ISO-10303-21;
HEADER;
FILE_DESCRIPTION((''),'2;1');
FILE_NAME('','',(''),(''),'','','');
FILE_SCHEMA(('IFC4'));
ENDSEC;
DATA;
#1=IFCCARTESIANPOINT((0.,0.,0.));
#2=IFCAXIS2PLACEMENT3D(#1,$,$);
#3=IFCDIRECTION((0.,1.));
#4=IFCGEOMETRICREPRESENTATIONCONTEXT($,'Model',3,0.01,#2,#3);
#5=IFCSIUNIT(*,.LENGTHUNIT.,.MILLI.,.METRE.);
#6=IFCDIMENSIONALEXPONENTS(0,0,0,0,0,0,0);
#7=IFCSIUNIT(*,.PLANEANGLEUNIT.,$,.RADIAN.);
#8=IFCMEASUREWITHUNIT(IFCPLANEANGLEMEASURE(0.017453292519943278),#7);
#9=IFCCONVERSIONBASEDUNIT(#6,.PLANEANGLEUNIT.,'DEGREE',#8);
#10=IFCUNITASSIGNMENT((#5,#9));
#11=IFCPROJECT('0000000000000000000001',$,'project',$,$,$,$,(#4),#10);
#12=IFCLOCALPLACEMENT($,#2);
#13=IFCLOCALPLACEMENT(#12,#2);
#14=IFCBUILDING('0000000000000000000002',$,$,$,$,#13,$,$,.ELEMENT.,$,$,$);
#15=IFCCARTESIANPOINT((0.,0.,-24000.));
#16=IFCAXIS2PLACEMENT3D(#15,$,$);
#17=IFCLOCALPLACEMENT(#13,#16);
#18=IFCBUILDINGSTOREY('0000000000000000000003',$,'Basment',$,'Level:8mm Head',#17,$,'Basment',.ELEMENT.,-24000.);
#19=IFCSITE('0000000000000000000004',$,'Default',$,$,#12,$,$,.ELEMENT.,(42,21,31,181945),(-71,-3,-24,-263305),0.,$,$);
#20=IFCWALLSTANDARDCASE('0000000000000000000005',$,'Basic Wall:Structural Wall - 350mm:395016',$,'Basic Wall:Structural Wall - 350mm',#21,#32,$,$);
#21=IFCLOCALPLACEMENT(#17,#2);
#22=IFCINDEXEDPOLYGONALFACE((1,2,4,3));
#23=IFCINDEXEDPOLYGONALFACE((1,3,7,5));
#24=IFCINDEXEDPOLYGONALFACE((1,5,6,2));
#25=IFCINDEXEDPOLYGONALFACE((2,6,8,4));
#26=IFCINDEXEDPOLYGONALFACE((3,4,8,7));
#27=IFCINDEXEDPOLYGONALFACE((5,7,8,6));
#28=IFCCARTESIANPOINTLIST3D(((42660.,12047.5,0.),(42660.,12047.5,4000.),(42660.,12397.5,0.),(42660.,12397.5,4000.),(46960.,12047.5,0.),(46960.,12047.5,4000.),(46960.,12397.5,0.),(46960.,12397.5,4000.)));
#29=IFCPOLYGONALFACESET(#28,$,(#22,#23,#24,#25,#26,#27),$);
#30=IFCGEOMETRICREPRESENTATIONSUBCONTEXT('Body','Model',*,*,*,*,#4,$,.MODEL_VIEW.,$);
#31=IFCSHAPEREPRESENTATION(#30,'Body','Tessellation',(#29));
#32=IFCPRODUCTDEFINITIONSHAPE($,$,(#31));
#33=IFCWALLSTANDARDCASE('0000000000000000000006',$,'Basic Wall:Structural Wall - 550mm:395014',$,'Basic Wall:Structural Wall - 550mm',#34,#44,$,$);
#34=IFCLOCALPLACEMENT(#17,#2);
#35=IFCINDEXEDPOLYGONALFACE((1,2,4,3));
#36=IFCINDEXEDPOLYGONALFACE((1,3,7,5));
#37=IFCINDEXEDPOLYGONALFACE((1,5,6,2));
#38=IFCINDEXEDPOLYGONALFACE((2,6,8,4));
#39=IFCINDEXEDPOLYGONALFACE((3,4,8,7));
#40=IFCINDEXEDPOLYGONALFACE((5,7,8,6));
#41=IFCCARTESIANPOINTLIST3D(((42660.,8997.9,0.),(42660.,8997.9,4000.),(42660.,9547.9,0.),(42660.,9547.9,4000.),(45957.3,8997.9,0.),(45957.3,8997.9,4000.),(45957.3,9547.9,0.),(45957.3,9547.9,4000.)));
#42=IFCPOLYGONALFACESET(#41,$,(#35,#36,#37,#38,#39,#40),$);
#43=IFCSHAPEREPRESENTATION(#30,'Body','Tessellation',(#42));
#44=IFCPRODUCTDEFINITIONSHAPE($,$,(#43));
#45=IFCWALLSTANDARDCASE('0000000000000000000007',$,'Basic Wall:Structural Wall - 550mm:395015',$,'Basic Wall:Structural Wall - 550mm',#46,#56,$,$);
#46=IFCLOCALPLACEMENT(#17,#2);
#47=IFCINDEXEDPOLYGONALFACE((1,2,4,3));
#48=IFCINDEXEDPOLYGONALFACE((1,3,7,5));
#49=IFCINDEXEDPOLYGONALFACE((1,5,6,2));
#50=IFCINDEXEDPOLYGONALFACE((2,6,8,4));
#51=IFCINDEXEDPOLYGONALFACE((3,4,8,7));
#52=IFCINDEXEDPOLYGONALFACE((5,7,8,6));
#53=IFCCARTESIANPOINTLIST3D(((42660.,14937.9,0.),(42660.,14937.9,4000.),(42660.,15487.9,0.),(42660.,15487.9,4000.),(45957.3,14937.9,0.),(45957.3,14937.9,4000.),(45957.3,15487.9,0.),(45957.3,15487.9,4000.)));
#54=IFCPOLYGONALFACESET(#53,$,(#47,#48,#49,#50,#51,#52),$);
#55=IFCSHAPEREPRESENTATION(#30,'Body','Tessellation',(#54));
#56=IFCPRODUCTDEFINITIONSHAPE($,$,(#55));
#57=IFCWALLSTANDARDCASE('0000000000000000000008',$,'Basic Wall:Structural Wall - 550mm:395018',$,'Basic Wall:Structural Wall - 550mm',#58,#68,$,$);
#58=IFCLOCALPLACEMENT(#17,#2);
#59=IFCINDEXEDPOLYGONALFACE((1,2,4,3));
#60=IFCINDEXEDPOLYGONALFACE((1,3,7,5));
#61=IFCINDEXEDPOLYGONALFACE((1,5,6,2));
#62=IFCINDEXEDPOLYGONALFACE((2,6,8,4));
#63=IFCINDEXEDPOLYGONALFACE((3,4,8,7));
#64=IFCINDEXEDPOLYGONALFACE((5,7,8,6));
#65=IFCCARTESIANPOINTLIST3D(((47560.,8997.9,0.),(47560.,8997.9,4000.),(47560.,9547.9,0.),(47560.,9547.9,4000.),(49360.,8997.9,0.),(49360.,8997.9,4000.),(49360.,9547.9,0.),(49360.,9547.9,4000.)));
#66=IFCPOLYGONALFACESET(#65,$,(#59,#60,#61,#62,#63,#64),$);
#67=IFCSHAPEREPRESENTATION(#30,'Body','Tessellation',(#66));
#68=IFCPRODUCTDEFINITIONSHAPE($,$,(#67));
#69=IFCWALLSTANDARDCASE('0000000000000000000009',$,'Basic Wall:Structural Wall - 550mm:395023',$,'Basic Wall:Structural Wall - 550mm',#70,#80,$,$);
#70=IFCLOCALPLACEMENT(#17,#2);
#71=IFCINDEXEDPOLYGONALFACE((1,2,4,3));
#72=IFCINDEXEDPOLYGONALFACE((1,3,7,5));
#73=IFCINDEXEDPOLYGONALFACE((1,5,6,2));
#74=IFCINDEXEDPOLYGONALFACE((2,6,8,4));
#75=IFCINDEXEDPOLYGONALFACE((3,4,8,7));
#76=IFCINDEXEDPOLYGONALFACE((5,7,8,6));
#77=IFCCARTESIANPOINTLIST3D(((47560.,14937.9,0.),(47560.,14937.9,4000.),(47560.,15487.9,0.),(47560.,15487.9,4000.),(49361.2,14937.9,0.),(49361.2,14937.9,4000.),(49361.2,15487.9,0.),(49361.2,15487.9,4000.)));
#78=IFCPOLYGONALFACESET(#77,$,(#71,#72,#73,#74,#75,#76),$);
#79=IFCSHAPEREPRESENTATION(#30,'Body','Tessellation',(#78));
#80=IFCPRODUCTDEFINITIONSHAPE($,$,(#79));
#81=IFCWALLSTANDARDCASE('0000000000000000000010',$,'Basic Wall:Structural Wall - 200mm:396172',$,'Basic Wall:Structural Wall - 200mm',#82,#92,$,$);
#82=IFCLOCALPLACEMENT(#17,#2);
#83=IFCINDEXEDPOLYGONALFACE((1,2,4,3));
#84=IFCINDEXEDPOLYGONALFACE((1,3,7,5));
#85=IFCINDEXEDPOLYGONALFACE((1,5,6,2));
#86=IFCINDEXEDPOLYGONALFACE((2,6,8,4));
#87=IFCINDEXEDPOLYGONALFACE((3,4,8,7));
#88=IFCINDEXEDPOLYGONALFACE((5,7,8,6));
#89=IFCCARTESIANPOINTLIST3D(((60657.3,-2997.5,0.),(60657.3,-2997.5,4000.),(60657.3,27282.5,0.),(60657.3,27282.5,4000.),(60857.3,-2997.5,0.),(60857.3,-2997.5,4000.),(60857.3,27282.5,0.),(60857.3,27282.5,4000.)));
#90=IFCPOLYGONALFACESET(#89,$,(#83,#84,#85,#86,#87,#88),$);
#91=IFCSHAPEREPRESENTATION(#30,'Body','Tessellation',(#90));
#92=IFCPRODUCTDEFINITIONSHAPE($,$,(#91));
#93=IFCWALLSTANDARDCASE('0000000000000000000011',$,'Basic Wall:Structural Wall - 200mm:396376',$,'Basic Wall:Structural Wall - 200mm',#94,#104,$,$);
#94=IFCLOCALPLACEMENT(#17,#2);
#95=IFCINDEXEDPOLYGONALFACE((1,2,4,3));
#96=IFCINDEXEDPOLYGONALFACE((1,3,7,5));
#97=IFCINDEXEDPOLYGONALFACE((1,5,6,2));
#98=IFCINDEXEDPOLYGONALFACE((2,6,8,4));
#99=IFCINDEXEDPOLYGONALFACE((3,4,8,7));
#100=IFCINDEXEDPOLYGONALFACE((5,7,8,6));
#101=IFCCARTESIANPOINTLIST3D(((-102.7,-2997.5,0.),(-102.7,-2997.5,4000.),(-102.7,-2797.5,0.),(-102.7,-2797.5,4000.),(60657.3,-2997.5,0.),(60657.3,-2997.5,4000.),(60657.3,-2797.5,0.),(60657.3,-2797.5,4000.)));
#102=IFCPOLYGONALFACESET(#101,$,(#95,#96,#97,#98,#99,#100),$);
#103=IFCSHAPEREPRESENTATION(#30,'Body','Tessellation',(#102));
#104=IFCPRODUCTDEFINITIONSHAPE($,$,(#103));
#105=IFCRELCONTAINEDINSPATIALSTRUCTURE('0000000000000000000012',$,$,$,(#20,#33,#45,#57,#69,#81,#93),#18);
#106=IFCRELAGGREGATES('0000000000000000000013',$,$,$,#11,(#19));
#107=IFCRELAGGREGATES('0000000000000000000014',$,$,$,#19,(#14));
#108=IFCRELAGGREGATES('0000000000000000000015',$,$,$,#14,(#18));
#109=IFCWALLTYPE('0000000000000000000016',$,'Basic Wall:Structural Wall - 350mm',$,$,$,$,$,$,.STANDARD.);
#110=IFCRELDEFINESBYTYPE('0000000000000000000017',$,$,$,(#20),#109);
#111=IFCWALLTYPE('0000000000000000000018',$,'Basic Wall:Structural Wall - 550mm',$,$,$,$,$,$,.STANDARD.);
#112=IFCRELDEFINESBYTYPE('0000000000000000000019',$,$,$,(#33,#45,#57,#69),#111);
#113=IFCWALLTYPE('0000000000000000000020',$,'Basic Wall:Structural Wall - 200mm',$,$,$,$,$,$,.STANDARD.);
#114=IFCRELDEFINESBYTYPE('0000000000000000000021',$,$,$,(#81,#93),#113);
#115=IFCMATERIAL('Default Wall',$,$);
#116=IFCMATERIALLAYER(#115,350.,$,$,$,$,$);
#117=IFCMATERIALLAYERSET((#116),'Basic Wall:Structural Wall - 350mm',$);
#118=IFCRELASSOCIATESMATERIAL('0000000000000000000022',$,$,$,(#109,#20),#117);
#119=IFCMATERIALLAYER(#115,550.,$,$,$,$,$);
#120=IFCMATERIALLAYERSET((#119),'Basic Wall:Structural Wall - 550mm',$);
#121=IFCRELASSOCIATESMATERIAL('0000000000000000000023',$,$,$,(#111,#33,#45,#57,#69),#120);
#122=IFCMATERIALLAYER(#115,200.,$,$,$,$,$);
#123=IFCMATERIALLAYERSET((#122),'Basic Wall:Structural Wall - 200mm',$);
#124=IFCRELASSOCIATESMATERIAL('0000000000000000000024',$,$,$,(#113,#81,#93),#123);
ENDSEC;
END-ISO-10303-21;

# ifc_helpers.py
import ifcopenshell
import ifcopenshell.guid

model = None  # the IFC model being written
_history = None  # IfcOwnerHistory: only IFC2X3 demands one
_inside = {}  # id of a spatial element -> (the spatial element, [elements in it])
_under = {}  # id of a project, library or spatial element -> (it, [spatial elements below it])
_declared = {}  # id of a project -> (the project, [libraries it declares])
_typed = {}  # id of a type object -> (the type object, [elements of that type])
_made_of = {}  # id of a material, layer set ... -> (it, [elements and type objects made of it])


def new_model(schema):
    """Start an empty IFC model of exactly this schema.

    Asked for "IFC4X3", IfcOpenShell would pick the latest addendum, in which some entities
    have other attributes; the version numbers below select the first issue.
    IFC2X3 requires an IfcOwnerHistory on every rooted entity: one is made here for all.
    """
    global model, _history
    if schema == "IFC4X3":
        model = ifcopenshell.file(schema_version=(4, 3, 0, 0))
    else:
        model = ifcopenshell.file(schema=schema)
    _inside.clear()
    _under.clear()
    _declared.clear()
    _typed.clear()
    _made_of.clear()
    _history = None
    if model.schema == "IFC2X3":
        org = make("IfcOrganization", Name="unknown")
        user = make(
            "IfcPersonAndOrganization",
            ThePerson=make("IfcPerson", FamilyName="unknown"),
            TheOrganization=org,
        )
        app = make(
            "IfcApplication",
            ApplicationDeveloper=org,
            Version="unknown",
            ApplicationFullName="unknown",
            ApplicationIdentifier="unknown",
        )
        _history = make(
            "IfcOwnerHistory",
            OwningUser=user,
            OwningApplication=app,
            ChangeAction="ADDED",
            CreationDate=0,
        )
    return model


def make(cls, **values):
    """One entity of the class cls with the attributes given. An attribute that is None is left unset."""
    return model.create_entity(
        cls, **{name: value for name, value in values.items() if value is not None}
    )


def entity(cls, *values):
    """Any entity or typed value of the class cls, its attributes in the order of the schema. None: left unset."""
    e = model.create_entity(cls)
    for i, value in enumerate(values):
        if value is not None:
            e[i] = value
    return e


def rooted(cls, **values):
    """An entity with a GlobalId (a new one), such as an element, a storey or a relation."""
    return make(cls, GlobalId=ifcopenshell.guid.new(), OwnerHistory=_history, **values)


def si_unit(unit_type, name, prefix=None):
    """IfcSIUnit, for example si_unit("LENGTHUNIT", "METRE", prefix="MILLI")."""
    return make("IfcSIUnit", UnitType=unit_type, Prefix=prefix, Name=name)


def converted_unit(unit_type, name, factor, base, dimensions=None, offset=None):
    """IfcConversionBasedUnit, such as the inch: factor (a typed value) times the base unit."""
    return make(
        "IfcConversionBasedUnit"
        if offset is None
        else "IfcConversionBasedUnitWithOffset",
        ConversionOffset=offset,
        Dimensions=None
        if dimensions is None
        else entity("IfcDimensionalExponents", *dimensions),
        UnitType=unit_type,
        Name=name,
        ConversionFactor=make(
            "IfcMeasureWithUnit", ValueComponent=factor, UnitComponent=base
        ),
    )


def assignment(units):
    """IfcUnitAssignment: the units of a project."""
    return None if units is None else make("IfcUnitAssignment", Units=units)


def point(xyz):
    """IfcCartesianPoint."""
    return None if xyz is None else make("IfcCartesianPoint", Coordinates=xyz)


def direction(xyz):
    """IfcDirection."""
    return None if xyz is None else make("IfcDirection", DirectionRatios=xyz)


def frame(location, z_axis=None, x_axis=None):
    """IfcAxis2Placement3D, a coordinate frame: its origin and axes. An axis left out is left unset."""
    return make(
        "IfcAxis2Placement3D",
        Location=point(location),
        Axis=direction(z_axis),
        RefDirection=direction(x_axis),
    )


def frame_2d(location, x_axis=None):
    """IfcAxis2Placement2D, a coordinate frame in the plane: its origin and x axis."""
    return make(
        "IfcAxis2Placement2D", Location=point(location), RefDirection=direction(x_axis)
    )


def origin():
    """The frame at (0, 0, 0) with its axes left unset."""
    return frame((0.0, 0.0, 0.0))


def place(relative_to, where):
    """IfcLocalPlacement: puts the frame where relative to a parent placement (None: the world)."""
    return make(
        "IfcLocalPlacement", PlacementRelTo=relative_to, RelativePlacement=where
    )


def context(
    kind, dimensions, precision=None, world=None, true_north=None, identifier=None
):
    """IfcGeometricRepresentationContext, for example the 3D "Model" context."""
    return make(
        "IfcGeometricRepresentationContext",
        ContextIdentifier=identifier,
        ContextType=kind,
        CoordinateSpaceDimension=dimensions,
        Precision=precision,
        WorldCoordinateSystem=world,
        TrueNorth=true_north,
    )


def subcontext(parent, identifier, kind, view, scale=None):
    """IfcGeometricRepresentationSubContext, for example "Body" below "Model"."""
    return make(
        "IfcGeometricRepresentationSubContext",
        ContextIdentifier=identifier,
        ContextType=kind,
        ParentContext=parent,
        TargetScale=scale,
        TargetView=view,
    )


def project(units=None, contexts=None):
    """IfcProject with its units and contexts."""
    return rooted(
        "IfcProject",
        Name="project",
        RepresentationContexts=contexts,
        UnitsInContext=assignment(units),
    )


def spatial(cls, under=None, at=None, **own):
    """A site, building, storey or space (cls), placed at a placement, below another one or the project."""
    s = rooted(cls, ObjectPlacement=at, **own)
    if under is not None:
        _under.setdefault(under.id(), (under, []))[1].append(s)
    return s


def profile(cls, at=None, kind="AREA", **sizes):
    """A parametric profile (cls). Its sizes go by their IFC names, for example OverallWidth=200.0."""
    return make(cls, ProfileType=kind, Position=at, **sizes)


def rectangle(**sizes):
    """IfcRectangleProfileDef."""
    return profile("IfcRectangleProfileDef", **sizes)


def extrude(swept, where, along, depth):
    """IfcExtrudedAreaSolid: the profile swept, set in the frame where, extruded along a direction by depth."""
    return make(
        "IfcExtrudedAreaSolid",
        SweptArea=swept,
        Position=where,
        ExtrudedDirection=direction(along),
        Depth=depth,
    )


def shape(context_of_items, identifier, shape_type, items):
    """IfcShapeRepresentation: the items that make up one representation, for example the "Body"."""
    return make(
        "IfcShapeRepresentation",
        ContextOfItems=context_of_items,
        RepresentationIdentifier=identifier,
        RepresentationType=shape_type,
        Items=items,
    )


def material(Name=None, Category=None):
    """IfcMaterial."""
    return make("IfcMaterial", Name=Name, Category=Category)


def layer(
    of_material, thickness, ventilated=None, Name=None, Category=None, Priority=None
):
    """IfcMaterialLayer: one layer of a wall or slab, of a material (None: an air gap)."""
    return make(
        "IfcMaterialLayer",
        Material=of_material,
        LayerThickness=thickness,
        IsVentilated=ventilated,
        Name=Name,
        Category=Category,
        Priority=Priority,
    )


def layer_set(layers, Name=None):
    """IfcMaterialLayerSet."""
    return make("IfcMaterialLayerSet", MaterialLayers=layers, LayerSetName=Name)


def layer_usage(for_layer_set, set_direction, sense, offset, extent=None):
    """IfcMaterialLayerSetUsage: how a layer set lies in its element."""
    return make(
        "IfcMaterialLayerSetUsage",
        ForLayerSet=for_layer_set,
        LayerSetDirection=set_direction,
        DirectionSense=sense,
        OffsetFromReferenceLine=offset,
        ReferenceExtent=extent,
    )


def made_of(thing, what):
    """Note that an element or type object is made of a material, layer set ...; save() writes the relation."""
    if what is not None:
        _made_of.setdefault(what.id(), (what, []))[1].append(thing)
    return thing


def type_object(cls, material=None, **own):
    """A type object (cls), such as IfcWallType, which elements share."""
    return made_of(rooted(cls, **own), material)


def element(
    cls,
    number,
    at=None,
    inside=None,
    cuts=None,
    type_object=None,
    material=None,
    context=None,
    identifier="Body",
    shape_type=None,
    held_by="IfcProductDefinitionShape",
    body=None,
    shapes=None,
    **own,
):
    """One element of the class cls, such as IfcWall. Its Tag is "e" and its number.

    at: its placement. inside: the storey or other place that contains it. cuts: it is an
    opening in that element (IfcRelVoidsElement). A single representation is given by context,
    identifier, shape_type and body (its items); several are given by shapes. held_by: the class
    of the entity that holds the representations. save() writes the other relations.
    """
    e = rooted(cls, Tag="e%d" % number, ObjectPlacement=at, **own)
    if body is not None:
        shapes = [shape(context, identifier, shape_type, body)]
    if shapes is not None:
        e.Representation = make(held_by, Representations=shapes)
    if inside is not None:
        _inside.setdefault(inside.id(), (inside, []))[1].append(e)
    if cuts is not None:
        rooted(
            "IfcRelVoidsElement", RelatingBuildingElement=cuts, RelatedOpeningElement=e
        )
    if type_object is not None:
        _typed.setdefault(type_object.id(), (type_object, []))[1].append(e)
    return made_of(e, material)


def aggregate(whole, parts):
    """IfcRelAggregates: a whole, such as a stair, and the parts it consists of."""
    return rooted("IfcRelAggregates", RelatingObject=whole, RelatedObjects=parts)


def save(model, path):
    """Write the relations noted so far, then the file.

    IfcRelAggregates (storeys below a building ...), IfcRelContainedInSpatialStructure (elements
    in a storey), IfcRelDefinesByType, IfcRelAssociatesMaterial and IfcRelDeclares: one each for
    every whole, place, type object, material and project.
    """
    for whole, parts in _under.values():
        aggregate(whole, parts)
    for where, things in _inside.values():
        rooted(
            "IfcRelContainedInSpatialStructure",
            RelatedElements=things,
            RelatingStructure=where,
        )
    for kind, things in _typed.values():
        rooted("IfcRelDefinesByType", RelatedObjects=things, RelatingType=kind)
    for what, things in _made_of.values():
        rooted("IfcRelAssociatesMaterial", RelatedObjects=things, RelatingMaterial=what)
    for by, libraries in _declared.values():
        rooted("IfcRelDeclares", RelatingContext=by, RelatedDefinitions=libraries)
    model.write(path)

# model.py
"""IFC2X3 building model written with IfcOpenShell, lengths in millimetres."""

from ifc_helpers import new_model, entity, si_unit, converted_unit, direction, frame, frame_2d, origin, place, context, subcontext, project, spatial, rectangle, extrude, material, layer, layer_set, layer_usage, type_object, element, save


model = new_model("IFC2X3")

# Units and contexts
model_context = context("Model", 3, precision=0.01, world=origin(), true_north=direction((0.0, 1.0)))
body_context = subcontext(model_context, "Body", "Model", "MODEL_VIEW")
ifc_project = project(units=[si_unit("LENGTHUNIT", "METRE", prefix="MILLI"), converted_unit("PLANEANGLEUNIT", "DEGREE", entity("IfcPlaneAngleMeasure", 0.017453292519943278), si_unit("PLANEANGLEUNIT", "RADIAN"), dimensions=[0, 0, 0, 0, 0, 0, 0])], contexts=[model_context])

# Site, building, storey
site_placement = place(None, origin())
site = spatial("IfcSite", under=ifc_project, at=site_placement, Name="Default", CompositionType="ELEMENT", RefLatitude=(42, 21, 31, 181945), RefLongitude=(-71, -3, -24, -263305), RefElevation=0.0)
building_placement = place(site_placement, origin())
building = spatial("IfcBuilding", under=site, at=building_placement, CompositionType="ELEMENT")
storey_placement = place(building_placement, frame((0.0, 0.0, -24000.0)))
storey = spatial("IfcBuildingStorey", under=building, at=storey_placement, Name="Basment", ObjectType="Level:8mm Head", LongName="Basment", CompositionType="ELEMENT", Elevation=-24000.0)

# Walls
ifc_material_1 = material(Name="Default Wall")
ifc_layer_1 = layer(ifc_material_1, 350.0)
ifc_layer_set_1 = layer_set([ifc_layer_1], Name="Basic Wall:Structural Wall - 350mm")
ifc_layer_usage_1 = layer_usage(ifc_layer_set_1, "AXIS2", "NEGATIVE", 175.0)
wall_type_1 = type_object("IfcWallType", Name="Basic Wall:Structural Wall - 350mm", PredefinedType="STANDARD", material=ifc_layer_set_1)
wall_1_placement = place(storey_placement, frame((42660.0, 12222.5, 0.0)))
element("IfcWallStandardCase", 1, at=wall_1_placement, inside=storey, type_object=wall_type_1, material=ifc_layer_usage_1, Name="Basic Wall:Structural Wall - 350mm:395016", ObjectType="Basic Wall:Structural Wall - 350mm", context=body_context, shape_type="SweptSolid", body=[
    extrude(rectangle(XDim=4300.0, YDim=350.0, at=frame_2d((2150.0, 0.0), x_axis=(-1.0, 0.0))), origin(), (0.0, 0.0, 1.0), 4000.0),
])
ifc_layer_2 = layer(ifc_material_1, 550.0)
ifc_layer_set_2 = layer_set([ifc_layer_2], Name="Basic Wall:Structural Wall - 550mm")
ifc_layer_usage_2 = layer_usage(ifc_layer_set_2, "AXIS2", "NEGATIVE", 275.0)
wall_type_2 = type_object("IfcWallType", Name="Basic Wall:Structural Wall - 550mm", PredefinedType="STANDARD", material=ifc_layer_set_2)
wall_2_placement = place(storey_placement, frame((42660.0, 9272.9, 0.0)))
element("IfcWallStandardCase", 2, at=wall_2_placement, inside=storey, type_object=wall_type_2, material=ifc_layer_usage_2, Name="Basic Wall:Structural Wall - 550mm:395014", ObjectType="Basic Wall:Structural Wall - 550mm", context=body_context, shape_type="SweptSolid", body=[
    extrude(rectangle(XDim=3297.3, YDim=550.0, at=frame_2d((1648.6, 0.0), x_axis=(-1.0, 0.0))), origin(), (0.0, 0.0, 1.0), 4000.0),
])
ifc_layer_usage_3 = layer_usage(ifc_layer_set_2, "AXIS2", "NEGATIVE", 275.0)
wall_3_placement = place(storey_placement, frame((45957.3, 15212.9, 0.0), z_axis=(0.0, 0.0, 1.0), x_axis=(-1.0, 0.0, 0.0)))
element("IfcWallStandardCase", 3, at=wall_3_placement, inside=storey, type_object=wall_type_2, material=ifc_layer_usage_3, Name="Basic Wall:Structural Wall - 550mm:395015", ObjectType="Basic Wall:Structural Wall - 550mm", context=body_context, shape_type="SweptSolid", body=[
    extrude(rectangle(XDim=3297.3, YDim=550.0, at=frame_2d((1648.6, 0.0), x_axis=(-1.0, 0.0))), origin(), (0.0, 0.0, 1.0), 4000.0),
])
ifc_layer_usage_4 = layer_usage(ifc_layer_set_2, "AXIS2", "NEGATIVE", 275.0)
wall_4_placement = place(storey_placement, frame((47560.0, 9272.9, 0.0)))
element("IfcWallStandardCase", 4, at=wall_4_placement, inside=storey, type_object=wall_type_2, material=ifc_layer_usage_4, Name="Basic Wall:Structural Wall - 550mm:395018", ObjectType="Basic Wall:Structural Wall - 550mm", context=body_context, shape_type="SweptSolid", body=[
    extrude(rectangle(XDim=1800.0, YDim=550.0, at=frame_2d((900.0, 0.0), x_axis=(-1.0, 0.0))), origin(), (0.0, 0.0, 1.0), 4000.0),
])
ifc_layer_usage_5 = layer_usage(ifc_layer_set_2, "AXIS2", "NEGATIVE", 275.0)
wall_5_placement = place(storey_placement, frame((49361.2, 15212.9, 0.0), z_axis=(0.0, 0.0, 1.0), x_axis=(-1.0, 0.0, 0.0)))
element("IfcWallStandardCase", 5, at=wall_5_placement, inside=storey, type_object=wall_type_2, material=ifc_layer_usage_5, Name="Basic Wall:Structural Wall - 550mm:395023", ObjectType="Basic Wall:Structural Wall - 550mm", context=body_context, shape_type="SweptSolid", body=[
    extrude(rectangle(XDim=1801.2, YDim=550.0, at=frame_2d((900.6, 0.0), x_axis=(-1.0, 0.0))), origin(), (0.0, 0.0, 1.0), 4000.0),
])
ifc_layer_3 = layer(ifc_material_1, 200.0)
ifc_layer_set_3 = layer_set([ifc_layer_3], Name="Basic Wall:Structural Wall - 200mm")
ifc_layer_usage_6 = layer_usage(ifc_layer_set_3, "AXIS2", "NEGATIVE", 100.0)
wall_type_3 = type_object("IfcWallType", Name="Basic Wall:Structural Wall - 200mm", PredefinedType="STANDARD", material=ifc_layer_set_3)
wall_6_placement = place(storey_placement, frame((60757.3, 27282.5, 0.0), z_axis=(0.0, 0.0, 1.0), x_axis=(0.0, -1.0, 0.0)))
element("IfcWallStandardCase", 6, at=wall_6_placement, inside=storey, type_object=wall_type_3, material=ifc_layer_usage_6, Name="Basic Wall:Structural Wall - 200mm:396172", ObjectType="Basic Wall:Structural Wall - 200mm", context=body_context, shape_type="SweptSolid", body=[
    extrude(rectangle(XDim=30280.0, YDim=200.0, at=frame_2d((15140.0, 0.0), x_axis=(-1.0, 0.0))), origin(), (0.0, 0.0, 1.0), 4000.0),
])
ifc_layer_usage_7 = layer_usage(ifc_layer_set_3, "AXIS2", "NEGATIVE", 100.0)
wall_7_placement = place(storey_placement, frame((60657.3, -2897.5, 0.0), z_axis=(0.0, 0.0, 1.0), x_axis=(-1.0, 0.0, 0.0)))
element("IfcWallStandardCase", 7, at=wall_7_placement, inside=storey, type_object=wall_type_3, material=ifc_layer_usage_7, Name="Basic Wall:Structural Wall - 200mm:396376", ObjectType="Basic Wall:Structural Wall - 200mm", context=body_context, shape_type="SweptSolid", body=[
    extrude(rectangle(XDim=60760.0, YDim=200.0, at=frame_2d((30380.0, 0.0), x_axis=(-1.0, 0.0))), origin(), (0.0, 0.0, 1.0), 4000.0),
])

save(model, "model.ifc")
